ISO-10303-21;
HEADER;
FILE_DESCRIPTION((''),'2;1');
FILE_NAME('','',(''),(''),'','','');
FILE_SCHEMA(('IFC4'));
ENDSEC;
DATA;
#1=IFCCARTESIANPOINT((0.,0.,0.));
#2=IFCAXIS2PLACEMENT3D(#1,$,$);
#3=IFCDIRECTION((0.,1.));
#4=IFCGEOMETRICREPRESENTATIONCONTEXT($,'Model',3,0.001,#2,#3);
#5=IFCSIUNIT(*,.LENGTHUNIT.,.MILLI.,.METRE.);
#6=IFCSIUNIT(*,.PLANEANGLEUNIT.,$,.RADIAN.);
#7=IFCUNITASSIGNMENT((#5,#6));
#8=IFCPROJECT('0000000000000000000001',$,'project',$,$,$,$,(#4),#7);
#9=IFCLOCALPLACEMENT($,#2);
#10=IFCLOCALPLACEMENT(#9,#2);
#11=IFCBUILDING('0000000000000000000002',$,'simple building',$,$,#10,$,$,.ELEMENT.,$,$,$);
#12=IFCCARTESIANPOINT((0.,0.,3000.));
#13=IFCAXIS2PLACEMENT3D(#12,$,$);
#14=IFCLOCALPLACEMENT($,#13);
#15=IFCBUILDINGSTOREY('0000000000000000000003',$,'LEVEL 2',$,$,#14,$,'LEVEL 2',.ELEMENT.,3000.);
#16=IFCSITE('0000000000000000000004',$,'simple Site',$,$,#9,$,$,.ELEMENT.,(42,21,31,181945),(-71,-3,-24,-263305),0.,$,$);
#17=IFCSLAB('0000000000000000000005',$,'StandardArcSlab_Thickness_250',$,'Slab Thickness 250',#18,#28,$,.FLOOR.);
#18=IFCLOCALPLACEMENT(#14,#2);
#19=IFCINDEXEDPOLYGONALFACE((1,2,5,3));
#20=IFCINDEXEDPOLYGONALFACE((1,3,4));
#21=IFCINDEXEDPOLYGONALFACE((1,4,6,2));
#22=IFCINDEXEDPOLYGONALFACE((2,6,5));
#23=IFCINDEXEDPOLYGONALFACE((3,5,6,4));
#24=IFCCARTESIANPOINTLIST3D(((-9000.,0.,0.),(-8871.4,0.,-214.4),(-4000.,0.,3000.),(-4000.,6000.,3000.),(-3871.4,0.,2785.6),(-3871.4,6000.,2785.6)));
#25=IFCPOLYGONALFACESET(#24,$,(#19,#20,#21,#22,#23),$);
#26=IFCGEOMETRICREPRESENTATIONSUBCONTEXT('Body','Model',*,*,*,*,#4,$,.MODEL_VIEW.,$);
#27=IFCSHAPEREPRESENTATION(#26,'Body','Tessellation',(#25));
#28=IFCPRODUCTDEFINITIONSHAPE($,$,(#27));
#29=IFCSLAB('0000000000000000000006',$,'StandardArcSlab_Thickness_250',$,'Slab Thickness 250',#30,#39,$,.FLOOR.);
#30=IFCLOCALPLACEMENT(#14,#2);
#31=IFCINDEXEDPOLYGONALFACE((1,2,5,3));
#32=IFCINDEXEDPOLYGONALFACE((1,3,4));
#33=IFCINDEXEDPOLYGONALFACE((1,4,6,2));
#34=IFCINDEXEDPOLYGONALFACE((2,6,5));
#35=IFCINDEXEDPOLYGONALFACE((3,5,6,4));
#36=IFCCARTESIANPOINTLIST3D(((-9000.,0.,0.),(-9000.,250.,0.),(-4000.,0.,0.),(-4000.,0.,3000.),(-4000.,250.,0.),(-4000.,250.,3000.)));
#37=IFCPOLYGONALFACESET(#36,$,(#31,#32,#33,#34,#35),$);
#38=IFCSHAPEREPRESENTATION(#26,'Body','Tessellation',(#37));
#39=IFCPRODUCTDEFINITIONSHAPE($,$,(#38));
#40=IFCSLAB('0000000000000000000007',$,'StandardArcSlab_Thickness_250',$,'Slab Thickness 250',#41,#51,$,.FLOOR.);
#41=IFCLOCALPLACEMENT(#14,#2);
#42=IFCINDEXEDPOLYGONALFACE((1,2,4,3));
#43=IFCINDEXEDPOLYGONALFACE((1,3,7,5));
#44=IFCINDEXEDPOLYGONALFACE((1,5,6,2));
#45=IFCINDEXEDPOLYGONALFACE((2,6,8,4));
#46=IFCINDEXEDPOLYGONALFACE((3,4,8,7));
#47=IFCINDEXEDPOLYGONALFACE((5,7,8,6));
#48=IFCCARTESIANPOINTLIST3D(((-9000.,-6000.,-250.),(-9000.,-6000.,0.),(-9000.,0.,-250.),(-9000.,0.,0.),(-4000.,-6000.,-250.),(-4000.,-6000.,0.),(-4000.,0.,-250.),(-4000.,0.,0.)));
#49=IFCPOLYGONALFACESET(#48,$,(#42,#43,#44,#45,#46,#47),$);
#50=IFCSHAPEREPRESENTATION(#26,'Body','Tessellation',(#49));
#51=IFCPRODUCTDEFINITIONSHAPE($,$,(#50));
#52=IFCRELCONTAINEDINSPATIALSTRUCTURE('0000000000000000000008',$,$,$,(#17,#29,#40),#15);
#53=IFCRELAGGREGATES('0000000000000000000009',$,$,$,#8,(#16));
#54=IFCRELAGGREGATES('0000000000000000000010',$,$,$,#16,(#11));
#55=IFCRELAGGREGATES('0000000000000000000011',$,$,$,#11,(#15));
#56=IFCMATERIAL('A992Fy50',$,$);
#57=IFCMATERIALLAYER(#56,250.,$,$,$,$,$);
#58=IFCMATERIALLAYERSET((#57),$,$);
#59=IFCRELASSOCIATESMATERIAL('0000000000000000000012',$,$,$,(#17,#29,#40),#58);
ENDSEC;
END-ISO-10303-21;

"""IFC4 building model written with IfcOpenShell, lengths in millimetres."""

from ifc_helpers import new_model, si_unit, direction, frame, origin, origin_with_axes, place, context, subcontext, project, spatial, polyline, outline, extrude, material, layer, layer_set, layer_usage, element, save


model = new_model("IFC4")

# Units and contexts
model_context = context("Model", 3, precision=0.001, world=origin(), true_north=direction((0.0, 1.0)))
body_context = subcontext(model_context, "Body", "Model", "MODEL_VIEW")
ifc_project = project(units=[si_unit("LENGTHUNIT", "METRE", prefix="MILLI"), si_unit("PLANEANGLEUNIT", "RADIAN")], contexts=[model_context])

# Site, building, storey
site_placement = place(None, origin())
site = spatial("IfcSite", under=ifc_project, at=site_placement, Name="simple Site", CompositionType="ELEMENT", RefLatitude=(42, 21, 31, 181945), RefLongitude=(-71, -3, -24, -263305), RefElevation=0.0)
building_placement = place(site_placement, origin())
building = spatial("IfcBuilding", under=site, at=building_placement, Name="simple building", CompositionType="ELEMENT")
storey_placement = place(None, frame((0.0, 0.0, 3000.0)))
storey = spatial("IfcBuildingStorey", under=building, at=storey_placement, Name="LEVEL 2", LongName="LEVEL 2", CompositionType="ELEMENT", Elevation=3000.0)

# Slabs
ifc_material_1 = material(Name="A992Fy50")
ifc_layer = layer(ifc_material_1, 250.0)
ifc_layer_set = layer_set([ifc_layer])
ifc_layer_usage = layer_usage(ifc_layer_set, "AXIS3", "POSITIVE", -250.0)
slab_1_placement = place(None, frame((-8871.4, 0.0, 2785.6), z_axis=(-0.514496, 0.0, 0.857493), x_axis=(0.857493, 0.0, 0.514496)))
element("IfcSlab", 1, at=slab_1_placement, inside=storey, material=ifc_layer_usage, Name="StandardArcSlab_Thickness_250", ObjectType="Slab Thickness 250", PredefinedType="FLOOR", context=body_context, shape_type="SweptSolid", body=[
    extrude(outline(polyline([(0.0, 0.0), (5831.0, 0.0), (5831.0, 6000.0), (0.0, 0.0)])), origin_with_axes(), (0.0, 0.0, 1.0), 250.0),
])
slab_2_placement = place(None, frame((-9000.0, 250.0, 3000.0), z_axis=(0.0, -1.0, 0.0), x_axis=(1.0, 0.0, 0.0)))
element("IfcSlab", 2, at=slab_2_placement, inside=storey, material=ifc_layer_usage, Name="StandardArcSlab_Thickness_250", ObjectType="Slab Thickness 250", PredefinedType="FLOOR", context=body_context, shape_type="SweptSolid", body=[
    extrude(outline(polyline([(0.0, 0.0), (5000.0, 0.0), (5000.0, 3000.0), (0.0, 0.0)])), origin_with_axes(), (0.0, 0.0, 1.0), 250.0),
])
slab_3_placement = place(None, frame((-9000.0, 0.0, 2750.0), z_axis=(0.0, 0.0, 1.0), x_axis=(0.0, -1.0, 0.0)))
element("IfcSlab", 3, at=slab_3_placement, inside=storey, material=ifc_layer_usage, Name="StandardArcSlab_Thickness_250", ObjectType="Slab Thickness 250", PredefinedType="FLOOR", context=body_context, shape_type="SweptSolid", body=[
    extrude(outline(polyline([(0.0, 0.0), (6000.0, 0.0), (6000.0, 5000.0), (0.0, 5000.0), (0.0, 0.0)])), origin_with_axes(), (0.0, 0.0, 1.0), 250.0),
])

save(model, "model.ifc")
